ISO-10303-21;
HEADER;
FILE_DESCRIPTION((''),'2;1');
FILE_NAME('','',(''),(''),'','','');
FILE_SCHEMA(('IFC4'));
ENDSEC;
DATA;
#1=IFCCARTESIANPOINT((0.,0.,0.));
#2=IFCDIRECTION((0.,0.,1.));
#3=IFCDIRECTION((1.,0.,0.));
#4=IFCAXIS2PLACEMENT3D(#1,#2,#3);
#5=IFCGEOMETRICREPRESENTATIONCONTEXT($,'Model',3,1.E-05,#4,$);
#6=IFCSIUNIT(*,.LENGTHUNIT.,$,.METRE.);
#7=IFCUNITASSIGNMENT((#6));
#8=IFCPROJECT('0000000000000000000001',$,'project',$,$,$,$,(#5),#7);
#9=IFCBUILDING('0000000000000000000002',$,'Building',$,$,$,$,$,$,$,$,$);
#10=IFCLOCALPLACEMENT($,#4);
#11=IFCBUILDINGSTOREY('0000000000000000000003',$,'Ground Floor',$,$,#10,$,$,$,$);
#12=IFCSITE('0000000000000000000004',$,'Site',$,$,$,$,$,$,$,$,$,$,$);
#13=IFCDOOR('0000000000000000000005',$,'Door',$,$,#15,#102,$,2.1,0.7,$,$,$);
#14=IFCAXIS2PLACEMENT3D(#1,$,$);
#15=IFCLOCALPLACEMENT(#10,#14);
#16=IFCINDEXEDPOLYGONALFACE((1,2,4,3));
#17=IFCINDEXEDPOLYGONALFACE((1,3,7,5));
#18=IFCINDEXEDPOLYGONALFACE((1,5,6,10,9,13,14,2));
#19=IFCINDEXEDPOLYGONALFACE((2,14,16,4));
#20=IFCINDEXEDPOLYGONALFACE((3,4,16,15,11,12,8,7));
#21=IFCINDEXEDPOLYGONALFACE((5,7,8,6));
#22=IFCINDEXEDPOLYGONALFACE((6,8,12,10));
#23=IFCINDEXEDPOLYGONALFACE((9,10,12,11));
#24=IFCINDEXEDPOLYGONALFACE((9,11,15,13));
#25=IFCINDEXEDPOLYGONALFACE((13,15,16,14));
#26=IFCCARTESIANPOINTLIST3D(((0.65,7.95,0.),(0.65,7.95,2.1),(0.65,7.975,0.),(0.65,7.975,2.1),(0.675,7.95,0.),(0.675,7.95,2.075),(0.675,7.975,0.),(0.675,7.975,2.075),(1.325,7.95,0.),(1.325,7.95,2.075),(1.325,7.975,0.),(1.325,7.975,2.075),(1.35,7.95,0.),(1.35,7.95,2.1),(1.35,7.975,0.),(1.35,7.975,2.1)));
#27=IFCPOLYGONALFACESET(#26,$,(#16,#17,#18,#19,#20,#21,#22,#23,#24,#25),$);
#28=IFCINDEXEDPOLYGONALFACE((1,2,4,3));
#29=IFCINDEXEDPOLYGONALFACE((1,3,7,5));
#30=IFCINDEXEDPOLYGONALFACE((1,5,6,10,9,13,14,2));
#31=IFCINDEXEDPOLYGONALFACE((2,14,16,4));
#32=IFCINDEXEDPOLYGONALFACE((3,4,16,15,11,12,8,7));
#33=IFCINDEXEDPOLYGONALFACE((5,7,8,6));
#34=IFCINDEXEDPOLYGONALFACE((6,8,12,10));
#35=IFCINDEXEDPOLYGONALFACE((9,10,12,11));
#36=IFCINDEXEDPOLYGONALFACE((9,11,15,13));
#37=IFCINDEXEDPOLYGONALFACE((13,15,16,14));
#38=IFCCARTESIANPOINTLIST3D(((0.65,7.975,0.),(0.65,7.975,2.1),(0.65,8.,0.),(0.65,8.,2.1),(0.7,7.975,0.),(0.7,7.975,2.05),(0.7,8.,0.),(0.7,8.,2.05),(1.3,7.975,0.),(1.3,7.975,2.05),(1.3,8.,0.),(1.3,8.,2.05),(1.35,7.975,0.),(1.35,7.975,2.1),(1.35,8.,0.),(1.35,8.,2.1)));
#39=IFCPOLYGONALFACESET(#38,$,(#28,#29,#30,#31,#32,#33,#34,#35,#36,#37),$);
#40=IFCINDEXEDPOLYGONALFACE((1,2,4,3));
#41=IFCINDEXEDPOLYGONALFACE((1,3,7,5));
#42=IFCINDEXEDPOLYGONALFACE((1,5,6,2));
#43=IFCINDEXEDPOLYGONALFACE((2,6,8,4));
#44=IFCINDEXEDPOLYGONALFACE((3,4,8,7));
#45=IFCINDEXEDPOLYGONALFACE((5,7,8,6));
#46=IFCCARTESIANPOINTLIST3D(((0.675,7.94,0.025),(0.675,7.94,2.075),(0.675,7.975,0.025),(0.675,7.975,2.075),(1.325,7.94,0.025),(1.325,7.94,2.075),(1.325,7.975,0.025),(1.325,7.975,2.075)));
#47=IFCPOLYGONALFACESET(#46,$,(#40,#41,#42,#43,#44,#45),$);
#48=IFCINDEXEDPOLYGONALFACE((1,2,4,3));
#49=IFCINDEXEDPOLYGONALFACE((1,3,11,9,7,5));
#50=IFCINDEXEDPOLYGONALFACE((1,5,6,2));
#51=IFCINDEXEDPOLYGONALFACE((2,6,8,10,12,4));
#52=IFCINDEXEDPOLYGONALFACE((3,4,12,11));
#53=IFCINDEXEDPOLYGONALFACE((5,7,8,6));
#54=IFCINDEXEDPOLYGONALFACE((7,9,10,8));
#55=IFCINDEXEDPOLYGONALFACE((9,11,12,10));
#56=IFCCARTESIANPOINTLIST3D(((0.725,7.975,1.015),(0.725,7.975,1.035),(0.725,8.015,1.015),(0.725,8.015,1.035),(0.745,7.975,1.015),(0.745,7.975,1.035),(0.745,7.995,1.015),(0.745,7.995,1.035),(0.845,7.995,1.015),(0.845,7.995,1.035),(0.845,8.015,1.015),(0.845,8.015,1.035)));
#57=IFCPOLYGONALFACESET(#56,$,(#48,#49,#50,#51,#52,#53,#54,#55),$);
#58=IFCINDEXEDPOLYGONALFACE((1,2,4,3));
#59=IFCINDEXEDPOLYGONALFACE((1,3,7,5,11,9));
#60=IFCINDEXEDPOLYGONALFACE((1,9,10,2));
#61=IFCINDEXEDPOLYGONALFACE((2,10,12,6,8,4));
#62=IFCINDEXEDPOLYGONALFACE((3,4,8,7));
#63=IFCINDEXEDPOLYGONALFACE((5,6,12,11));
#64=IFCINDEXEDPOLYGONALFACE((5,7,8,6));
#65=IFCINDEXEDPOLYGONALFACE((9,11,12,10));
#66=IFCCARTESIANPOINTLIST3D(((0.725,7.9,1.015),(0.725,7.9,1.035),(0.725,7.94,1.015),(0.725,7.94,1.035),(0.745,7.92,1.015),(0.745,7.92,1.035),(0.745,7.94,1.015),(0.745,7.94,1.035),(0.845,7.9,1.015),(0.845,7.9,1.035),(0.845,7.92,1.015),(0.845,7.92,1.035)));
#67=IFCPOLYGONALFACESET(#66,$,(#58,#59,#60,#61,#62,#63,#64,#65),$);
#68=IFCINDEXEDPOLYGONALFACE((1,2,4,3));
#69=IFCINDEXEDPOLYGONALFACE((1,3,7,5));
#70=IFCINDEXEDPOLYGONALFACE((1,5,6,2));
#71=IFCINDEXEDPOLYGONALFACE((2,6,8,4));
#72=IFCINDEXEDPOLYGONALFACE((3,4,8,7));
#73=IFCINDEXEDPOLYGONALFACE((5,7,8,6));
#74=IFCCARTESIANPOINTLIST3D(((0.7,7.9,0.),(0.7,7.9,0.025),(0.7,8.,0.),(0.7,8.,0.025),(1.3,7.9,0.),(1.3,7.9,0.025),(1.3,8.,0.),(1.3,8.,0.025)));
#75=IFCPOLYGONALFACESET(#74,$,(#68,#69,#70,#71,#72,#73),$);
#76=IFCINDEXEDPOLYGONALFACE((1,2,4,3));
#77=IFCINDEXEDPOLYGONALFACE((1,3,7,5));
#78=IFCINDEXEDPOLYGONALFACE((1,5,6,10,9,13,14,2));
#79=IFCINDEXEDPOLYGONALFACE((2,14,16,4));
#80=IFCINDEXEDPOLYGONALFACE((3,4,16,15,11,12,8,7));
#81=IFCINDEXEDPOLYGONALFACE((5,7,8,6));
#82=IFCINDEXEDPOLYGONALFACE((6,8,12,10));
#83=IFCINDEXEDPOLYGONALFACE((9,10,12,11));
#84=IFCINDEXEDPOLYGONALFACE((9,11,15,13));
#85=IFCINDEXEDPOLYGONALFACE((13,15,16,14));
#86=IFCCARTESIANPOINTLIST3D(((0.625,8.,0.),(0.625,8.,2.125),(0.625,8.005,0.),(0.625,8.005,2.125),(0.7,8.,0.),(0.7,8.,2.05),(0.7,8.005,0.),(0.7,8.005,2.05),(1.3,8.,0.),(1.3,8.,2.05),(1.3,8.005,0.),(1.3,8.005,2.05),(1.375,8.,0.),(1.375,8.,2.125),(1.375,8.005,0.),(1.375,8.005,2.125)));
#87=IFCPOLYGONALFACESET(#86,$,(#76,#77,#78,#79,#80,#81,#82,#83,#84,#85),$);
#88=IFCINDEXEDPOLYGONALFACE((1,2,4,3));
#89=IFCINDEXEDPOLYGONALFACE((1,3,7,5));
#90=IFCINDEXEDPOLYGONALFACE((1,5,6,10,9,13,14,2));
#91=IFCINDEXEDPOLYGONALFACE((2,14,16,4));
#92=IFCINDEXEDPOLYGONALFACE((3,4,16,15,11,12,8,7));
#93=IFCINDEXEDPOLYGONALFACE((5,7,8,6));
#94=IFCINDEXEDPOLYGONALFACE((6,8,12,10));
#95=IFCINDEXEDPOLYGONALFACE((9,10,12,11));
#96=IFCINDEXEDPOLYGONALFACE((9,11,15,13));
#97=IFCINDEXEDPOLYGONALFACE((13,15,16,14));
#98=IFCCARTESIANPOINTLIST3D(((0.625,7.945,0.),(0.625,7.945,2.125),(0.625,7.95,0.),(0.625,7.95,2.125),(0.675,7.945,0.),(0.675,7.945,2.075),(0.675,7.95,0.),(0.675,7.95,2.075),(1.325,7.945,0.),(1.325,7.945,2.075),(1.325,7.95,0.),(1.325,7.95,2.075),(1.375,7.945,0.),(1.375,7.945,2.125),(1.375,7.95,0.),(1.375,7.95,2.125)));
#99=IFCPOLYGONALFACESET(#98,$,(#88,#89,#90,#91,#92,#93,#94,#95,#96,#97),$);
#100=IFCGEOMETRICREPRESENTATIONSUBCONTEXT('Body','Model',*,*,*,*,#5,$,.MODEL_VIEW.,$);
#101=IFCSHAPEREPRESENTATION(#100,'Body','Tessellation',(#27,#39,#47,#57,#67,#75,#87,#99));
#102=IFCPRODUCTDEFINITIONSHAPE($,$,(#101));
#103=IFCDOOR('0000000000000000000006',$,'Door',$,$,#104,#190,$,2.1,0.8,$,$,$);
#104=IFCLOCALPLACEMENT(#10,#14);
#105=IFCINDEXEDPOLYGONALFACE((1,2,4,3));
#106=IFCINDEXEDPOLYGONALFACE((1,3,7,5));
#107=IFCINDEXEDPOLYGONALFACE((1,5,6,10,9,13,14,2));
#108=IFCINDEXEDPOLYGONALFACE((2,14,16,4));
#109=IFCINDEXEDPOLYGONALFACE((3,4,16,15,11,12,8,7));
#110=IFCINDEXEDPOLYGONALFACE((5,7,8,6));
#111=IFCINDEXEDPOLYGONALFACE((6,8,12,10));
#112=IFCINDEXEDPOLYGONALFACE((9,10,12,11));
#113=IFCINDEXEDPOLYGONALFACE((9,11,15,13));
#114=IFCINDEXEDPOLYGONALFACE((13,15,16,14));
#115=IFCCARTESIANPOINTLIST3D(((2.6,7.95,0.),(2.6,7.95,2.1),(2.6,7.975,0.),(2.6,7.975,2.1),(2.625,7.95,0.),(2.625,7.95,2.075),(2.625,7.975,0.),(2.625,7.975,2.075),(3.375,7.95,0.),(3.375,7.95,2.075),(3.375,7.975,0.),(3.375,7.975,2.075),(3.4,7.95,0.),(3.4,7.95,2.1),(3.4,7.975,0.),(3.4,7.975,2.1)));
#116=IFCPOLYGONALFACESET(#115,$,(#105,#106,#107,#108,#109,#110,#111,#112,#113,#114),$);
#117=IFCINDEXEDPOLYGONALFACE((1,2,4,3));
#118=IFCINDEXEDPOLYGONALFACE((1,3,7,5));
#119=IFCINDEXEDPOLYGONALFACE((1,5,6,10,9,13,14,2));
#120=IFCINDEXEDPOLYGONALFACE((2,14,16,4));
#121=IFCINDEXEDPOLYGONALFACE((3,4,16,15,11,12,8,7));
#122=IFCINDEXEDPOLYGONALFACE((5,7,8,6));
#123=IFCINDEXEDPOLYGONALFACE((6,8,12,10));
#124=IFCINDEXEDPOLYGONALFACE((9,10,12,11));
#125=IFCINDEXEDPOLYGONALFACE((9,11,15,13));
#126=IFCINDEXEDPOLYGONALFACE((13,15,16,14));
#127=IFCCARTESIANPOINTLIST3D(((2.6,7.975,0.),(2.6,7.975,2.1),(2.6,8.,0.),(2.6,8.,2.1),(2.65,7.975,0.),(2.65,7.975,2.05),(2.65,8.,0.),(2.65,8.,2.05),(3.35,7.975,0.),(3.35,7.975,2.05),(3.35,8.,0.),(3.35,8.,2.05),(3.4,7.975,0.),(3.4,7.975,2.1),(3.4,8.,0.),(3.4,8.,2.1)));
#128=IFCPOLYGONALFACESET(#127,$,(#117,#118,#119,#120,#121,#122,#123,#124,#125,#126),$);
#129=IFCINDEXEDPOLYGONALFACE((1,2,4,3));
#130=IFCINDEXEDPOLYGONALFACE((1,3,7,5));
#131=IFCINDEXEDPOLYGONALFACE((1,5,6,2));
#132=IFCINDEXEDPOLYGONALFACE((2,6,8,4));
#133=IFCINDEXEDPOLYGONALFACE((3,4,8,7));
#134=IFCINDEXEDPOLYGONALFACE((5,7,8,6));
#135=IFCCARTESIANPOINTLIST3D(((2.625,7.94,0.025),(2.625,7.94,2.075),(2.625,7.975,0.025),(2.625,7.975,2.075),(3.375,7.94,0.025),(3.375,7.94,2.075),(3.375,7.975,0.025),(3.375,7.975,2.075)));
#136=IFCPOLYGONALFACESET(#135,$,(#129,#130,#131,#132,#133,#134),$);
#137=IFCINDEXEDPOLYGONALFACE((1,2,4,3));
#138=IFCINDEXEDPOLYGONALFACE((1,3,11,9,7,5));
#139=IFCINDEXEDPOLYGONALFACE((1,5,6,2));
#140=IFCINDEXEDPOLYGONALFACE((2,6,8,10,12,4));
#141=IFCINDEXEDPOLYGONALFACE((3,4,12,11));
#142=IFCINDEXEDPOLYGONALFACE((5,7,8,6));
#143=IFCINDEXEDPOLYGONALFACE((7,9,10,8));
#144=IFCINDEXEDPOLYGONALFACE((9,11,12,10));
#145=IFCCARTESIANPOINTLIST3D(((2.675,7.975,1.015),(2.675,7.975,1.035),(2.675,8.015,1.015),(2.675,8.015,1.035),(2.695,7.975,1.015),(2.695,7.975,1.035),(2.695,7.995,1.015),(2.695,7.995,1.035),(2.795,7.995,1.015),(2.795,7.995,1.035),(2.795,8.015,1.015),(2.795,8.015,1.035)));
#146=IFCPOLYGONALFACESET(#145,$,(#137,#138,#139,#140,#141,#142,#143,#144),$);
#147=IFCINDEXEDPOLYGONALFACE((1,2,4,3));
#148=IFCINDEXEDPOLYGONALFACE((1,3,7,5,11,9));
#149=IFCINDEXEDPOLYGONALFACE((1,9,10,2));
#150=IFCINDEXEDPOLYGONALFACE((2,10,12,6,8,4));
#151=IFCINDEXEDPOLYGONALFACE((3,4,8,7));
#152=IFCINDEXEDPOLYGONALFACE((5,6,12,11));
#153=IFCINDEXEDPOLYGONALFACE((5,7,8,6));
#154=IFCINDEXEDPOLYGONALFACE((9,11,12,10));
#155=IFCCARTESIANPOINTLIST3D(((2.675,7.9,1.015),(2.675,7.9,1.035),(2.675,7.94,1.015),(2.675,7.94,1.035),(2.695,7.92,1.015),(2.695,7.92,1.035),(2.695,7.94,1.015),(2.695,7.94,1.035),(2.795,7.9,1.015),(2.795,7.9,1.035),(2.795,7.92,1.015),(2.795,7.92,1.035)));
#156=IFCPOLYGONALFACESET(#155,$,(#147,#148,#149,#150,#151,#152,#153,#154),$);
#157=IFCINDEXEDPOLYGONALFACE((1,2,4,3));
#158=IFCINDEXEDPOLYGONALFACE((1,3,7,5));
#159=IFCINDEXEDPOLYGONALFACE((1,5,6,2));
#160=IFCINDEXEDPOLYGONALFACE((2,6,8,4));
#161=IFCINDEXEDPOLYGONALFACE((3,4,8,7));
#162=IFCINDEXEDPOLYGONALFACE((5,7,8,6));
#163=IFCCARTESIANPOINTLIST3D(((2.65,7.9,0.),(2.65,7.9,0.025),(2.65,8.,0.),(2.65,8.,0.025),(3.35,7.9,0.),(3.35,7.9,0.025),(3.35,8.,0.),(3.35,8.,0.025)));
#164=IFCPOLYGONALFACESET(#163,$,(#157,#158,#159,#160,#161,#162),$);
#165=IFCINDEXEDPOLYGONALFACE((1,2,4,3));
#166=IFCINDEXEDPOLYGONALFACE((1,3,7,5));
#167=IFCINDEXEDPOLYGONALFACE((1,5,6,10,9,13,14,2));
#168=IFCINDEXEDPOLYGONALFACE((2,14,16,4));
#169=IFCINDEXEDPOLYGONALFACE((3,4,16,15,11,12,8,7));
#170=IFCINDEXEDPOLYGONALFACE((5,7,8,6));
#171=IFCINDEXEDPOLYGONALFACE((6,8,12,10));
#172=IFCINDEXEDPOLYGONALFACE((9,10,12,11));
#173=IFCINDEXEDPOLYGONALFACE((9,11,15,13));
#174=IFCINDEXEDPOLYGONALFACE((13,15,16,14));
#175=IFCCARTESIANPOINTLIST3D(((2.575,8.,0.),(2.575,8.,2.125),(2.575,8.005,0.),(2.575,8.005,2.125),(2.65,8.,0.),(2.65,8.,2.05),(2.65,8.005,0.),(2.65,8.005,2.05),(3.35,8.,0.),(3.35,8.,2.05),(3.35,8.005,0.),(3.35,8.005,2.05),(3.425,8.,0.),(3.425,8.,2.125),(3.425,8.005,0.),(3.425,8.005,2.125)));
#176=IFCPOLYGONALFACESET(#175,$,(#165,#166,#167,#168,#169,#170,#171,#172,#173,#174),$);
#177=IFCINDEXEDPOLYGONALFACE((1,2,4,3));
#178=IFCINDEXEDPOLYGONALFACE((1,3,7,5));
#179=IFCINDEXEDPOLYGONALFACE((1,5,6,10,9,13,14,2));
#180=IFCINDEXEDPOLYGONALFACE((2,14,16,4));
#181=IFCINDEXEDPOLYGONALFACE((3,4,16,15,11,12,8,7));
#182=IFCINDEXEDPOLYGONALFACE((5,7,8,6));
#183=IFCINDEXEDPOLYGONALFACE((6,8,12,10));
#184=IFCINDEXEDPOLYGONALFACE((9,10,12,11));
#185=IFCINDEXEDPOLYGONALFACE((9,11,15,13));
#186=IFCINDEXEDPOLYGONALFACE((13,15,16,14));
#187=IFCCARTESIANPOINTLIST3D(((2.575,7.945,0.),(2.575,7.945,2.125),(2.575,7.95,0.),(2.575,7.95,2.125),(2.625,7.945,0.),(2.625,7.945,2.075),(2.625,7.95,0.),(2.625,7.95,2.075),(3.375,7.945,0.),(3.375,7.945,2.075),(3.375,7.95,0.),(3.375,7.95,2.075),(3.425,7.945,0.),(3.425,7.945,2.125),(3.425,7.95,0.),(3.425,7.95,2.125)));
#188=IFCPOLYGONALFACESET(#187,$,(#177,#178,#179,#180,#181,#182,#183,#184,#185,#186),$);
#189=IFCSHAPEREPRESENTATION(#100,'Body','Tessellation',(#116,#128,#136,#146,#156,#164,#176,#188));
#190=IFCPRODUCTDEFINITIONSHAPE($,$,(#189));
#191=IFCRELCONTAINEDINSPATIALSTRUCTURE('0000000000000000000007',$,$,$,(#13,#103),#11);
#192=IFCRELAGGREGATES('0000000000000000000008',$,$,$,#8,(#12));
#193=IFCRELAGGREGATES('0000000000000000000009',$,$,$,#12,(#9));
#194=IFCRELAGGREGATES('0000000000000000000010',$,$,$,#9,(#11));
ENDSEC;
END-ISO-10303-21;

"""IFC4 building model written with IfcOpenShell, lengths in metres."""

from ifc_helpers import new_model, si_unit, frame, origin_with_axes, place, context, subcontext, project, spatial, line, indexed_curve, outline, extrude, element, save


model = new_model("IFC4")

# Units and contexts
model_context = context("Model", 3, precision=1e-05, world=origin_with_axes())
body_context = subcontext(model_context, "Body", "Model", "MODEL_VIEW")
ifc_project = project(units=[si_unit("LENGTHUNIT", "METRE")], contexts=[model_context])

# Site, building, storey
site = spatial("IfcSite", under=ifc_project, Name="Site")
building = spatial("IfcBuilding", under=site, Name="Building")
storey_placement = place(None, origin_with_axes())
storey = spatial("IfcBuildingStorey", under=building, at=storey_placement, Name="Ground Floor")

# Doors
door_1_placement = place(storey_placement, frame((1.35, 8.0, 0.0), z_axis=(0.0, 0.0, 1.0), x_axis=(-1.0, 0.0, 0.0)))
element("IfcDoor", 1, at=door_1_placement, inside=storey, Name="Door", OverallHeight=2.1, OverallWidth=0.7, context=body_context, shape_type="SweptSolid", body=[
    extrude(outline(indexed_curve([(0.0, 0.0), (0.0, 2.1), (0.7, 2.1), (0.7, 0.0), (0.675, 0.0), (0.675, 2.075), (0.025, 2.075), (0.025, 0.0)], segments=[line(1, 2, 3, 4, 5, 6, 7, 8, 1)])), frame((0.0, 0.025, 0.0), z_axis=(0.0, -1.0, 0.0), x_axis=(1.0, 0.0, 0.0)), (0.0, 0.0, -1.0), 0.025),
    extrude(outline(indexed_curve([(0.0, 0.0), (0.0, 2.1), (0.7, 2.1), (0.7, 0.0), (0.65, 0.0), (0.65, 2.05), (0.05, 2.05), (0.05, 0.0)], segments=[line(1, 2, 3, 4, 5, 6, 7, 8, 1)])), frame((0.0, 0.0, 0.0), z_axis=(0.0, -1.0, 0.0), x_axis=(1.0, 0.0, 0.0)), (0.0, 0.0, -1.0), 0.025),
    extrude(outline(indexed_curve([(0.0, 0.0), (0.65, 0.0), (0.65, 0.035), (0.0, 0.035)], segments=[line(1, 2, 3, 4, 1)])), frame((0.025, 0.025, 0.025), z_axis=(0.0, 0.0, 1.0), x_axis=(1.0, 0.0, 0.0)), (0.0, 0.0, 1.0), 2.05),
    extrude(outline(indexed_curve([(0.0, 0.0), (0.0, -0.04), (-0.12, -0.04), (-0.12, -0.02), (-0.02, -0.02), (-0.02, 0.0)], segments=[line(1, 2, 3, 4, 5, 6, 1)])), frame((0.625, 0.025, 1.015), z_axis=(0.0, 0.0, 1.0), x_axis=(1.0, 0.0, 0.0)), (0.0, 0.0, 1.0), 0.02),
    extrude(outline(indexed_curve([(0.0, 0.0), (0.0, 0.04), (-0.12, 0.04), (-0.12, 0.02), (-0.02, 0.02), (-0.02, 0.0)], segments=[line(1, 2, 3, 4, 5, 6, 1)])), frame((0.625, 0.06, 1.015), z_axis=(0.0, 0.0, 1.0), x_axis=(1.0, 0.0, 0.0)), (0.0, 0.0, 1.0), 0.02),
    extrude(outline(indexed_curve([(0.0, 0.0), (0.6, 0.0), (0.6, 0.1), (0.0, 0.1)], segments=[line(1, 2, 3, 4, 1)])), frame((0.05, 0.0, 0.0), z_axis=(0.0, 0.0, 1.0), x_axis=(1.0, 0.0, 0.0)), (0.0, 0.0, 1.0), 0.025),
    extrude(outline(indexed_curve([(0.0, 0.0), (0.0, 2.125), (0.75, 2.125), (0.75, 0.0), (0.675, 0.0), (0.675, 2.05), (0.075, 2.05), (0.075, 0.0)], segments=[line(1, 2, 3, 4, 5, 6, 7, 8, 1)])), frame((-0.025, -0.005, 0.0), z_axis=(0.0, -1.0, 0.0), x_axis=(1.0, 0.0, 0.0)), (0.0, 0.0, -1.0), 0.005),
    extrude(outline(indexed_curve([(0.0, 0.0), (0.0, 2.125), (0.75, 2.125), (0.75, 0.0), (0.7, 0.0), (0.7, 2.075), (0.05, 2.075), (0.05, 0.0)], segments=[line(1, 2, 3, 4, 5, 6, 7, 8, 1)])), frame((-0.025, 0.05, 0.0), z_axis=(0.0, -1.0, 0.0), x_axis=(1.0, 0.0, 0.0)), (0.0, 0.0, -1.0), 0.005),
])
door_2_placement = place(storey_placement, frame((3.4, 8.0, 0.0), z_axis=(0.0, 0.0, 1.0), x_axis=(-1.0, 0.0, 0.0)))
element("IfcDoor", 2, at=door_2_placement, inside=storey, Name="Door", OverallHeight=2.1, OverallWidth=0.8, context=body_context, shape_type="SweptSolid", body=[
    extrude(outline(indexed_curve([(0.0, 0.0), (0.0, 2.1), (0.8, 2.1), (0.8, 0.0), (0.775, 0.0), (0.775, 2.075), (0.025, 2.075), (0.025, 0.0)], segments=[line(1, 2, 3, 4, 5, 6, 7, 8, 1)])), frame((0.0, 0.025, 0.0), z_axis=(0.0, -1.0, 0.0), x_axis=(1.0, 0.0, 0.0)), (0.0, 0.0, -1.0), 0.025),
    extrude(outline(indexed_curve([(0.0, 0.0), (0.0, 2.1), (0.8, 2.1), (0.8, 0.0), (0.75, 0.0), (0.75, 2.05), (0.05, 2.05), (0.05, 0.0)], segments=[line(1, 2, 3, 4, 5, 6, 7, 8, 1)])), frame((0.0, 0.0, 0.0), z_axis=(0.0, -1.0, 0.0), x_axis=(1.0, 0.0, 0.0)), (0.0, 0.0, -1.0), 0.025),
    extrude(outline(indexed_curve([(0.0, 0.0), (0.75, 0.0), (0.75, 0.035), (0.0, 0.035)], segments=[line(1, 2, 3, 4, 1)])), frame((0.025, 0.025, 0.025), z_axis=(0.0, 0.0, 1.0), x_axis=(1.0, 0.0, 0.0)), (0.0, 0.0, 1.0), 2.05),
    extrude(outline(indexed_curve([(0.0, 0.0), (0.0, -0.04), (-0.12, -0.04), (-0.12, -0.02), (-0.02, -0.02), (-0.02, 0.0)], segments=[line(1, 2, 3, 4, 5, 6, 1)])), frame((0.725, 0.025, 1.015), z_axis=(0.0, 0.0, 1.0), x_axis=(1.0, 0.0, 0.0)), (0.0, 0.0, 1.0), 0.02),
    extrude(outline(indexed_curve([(0.0, 0.0), (0.0, 0.04), (-0.12, 0.04), (-0.12, 0.02), (-0.02, 0.02), (-0.02, 0.0)], segments=[line(1, 2, 3, 4, 5, 6, 1)])), frame((0.725, 0.06, 1.015), z_axis=(0.0, 0.0, 1.0), x_axis=(1.0, 0.0, 0.0)), (0.0, 0.0, 1.0), 0.02),
    extrude(outline(indexed_curve([(0.0, 0.0), (0.7, 0.0), (0.7, 0.1), (0.0, 0.1)], segments=[line(1, 2, 3, 4, 1)])), frame((0.05, 0.0, 0.0), z_axis=(0.0, 0.0, 1.0), x_axis=(1.0, 0.0, 0.0)), (0.0, 0.0, 1.0), 0.025),
    extrude(outline(indexed_curve([(0.0, 0.0), (0.0, 2.125), (0.85, 2.125), (0.85, 0.0), (0.775, 0.0), (0.775, 2.05), (0.075, 2.05), (0.075, 0.0)], segments=[line(1, 2, 3, 4, 5, 6, 7, 8, 1)])), frame((-0.025, -0.005, 0.0), z_axis=(0.0, -1.0, 0.0), x_axis=(1.0, 0.0, 0.0)), (0.0, 0.0, -1.0), 0.005),
    extrude(outline(indexed_curve([(0.0, 0.0), (0.0, 2.125), (0.85, 2.125), (0.85, 0.0), (0.8, 0.0), (0.8, 2.075), (0.05, 2.075), (0.05, 0.0)], segments=[line(1, 2, 3, 4, 5, 6, 7, 8, 1)])), frame((-0.025, 0.05, 0.0), z_axis=(0.0, -1.0, 0.0), x_axis=(1.0, 0.0, 0.0)), (0.0, 0.0, -1.0), 0.005),
])

save(model, "model.ifc")
